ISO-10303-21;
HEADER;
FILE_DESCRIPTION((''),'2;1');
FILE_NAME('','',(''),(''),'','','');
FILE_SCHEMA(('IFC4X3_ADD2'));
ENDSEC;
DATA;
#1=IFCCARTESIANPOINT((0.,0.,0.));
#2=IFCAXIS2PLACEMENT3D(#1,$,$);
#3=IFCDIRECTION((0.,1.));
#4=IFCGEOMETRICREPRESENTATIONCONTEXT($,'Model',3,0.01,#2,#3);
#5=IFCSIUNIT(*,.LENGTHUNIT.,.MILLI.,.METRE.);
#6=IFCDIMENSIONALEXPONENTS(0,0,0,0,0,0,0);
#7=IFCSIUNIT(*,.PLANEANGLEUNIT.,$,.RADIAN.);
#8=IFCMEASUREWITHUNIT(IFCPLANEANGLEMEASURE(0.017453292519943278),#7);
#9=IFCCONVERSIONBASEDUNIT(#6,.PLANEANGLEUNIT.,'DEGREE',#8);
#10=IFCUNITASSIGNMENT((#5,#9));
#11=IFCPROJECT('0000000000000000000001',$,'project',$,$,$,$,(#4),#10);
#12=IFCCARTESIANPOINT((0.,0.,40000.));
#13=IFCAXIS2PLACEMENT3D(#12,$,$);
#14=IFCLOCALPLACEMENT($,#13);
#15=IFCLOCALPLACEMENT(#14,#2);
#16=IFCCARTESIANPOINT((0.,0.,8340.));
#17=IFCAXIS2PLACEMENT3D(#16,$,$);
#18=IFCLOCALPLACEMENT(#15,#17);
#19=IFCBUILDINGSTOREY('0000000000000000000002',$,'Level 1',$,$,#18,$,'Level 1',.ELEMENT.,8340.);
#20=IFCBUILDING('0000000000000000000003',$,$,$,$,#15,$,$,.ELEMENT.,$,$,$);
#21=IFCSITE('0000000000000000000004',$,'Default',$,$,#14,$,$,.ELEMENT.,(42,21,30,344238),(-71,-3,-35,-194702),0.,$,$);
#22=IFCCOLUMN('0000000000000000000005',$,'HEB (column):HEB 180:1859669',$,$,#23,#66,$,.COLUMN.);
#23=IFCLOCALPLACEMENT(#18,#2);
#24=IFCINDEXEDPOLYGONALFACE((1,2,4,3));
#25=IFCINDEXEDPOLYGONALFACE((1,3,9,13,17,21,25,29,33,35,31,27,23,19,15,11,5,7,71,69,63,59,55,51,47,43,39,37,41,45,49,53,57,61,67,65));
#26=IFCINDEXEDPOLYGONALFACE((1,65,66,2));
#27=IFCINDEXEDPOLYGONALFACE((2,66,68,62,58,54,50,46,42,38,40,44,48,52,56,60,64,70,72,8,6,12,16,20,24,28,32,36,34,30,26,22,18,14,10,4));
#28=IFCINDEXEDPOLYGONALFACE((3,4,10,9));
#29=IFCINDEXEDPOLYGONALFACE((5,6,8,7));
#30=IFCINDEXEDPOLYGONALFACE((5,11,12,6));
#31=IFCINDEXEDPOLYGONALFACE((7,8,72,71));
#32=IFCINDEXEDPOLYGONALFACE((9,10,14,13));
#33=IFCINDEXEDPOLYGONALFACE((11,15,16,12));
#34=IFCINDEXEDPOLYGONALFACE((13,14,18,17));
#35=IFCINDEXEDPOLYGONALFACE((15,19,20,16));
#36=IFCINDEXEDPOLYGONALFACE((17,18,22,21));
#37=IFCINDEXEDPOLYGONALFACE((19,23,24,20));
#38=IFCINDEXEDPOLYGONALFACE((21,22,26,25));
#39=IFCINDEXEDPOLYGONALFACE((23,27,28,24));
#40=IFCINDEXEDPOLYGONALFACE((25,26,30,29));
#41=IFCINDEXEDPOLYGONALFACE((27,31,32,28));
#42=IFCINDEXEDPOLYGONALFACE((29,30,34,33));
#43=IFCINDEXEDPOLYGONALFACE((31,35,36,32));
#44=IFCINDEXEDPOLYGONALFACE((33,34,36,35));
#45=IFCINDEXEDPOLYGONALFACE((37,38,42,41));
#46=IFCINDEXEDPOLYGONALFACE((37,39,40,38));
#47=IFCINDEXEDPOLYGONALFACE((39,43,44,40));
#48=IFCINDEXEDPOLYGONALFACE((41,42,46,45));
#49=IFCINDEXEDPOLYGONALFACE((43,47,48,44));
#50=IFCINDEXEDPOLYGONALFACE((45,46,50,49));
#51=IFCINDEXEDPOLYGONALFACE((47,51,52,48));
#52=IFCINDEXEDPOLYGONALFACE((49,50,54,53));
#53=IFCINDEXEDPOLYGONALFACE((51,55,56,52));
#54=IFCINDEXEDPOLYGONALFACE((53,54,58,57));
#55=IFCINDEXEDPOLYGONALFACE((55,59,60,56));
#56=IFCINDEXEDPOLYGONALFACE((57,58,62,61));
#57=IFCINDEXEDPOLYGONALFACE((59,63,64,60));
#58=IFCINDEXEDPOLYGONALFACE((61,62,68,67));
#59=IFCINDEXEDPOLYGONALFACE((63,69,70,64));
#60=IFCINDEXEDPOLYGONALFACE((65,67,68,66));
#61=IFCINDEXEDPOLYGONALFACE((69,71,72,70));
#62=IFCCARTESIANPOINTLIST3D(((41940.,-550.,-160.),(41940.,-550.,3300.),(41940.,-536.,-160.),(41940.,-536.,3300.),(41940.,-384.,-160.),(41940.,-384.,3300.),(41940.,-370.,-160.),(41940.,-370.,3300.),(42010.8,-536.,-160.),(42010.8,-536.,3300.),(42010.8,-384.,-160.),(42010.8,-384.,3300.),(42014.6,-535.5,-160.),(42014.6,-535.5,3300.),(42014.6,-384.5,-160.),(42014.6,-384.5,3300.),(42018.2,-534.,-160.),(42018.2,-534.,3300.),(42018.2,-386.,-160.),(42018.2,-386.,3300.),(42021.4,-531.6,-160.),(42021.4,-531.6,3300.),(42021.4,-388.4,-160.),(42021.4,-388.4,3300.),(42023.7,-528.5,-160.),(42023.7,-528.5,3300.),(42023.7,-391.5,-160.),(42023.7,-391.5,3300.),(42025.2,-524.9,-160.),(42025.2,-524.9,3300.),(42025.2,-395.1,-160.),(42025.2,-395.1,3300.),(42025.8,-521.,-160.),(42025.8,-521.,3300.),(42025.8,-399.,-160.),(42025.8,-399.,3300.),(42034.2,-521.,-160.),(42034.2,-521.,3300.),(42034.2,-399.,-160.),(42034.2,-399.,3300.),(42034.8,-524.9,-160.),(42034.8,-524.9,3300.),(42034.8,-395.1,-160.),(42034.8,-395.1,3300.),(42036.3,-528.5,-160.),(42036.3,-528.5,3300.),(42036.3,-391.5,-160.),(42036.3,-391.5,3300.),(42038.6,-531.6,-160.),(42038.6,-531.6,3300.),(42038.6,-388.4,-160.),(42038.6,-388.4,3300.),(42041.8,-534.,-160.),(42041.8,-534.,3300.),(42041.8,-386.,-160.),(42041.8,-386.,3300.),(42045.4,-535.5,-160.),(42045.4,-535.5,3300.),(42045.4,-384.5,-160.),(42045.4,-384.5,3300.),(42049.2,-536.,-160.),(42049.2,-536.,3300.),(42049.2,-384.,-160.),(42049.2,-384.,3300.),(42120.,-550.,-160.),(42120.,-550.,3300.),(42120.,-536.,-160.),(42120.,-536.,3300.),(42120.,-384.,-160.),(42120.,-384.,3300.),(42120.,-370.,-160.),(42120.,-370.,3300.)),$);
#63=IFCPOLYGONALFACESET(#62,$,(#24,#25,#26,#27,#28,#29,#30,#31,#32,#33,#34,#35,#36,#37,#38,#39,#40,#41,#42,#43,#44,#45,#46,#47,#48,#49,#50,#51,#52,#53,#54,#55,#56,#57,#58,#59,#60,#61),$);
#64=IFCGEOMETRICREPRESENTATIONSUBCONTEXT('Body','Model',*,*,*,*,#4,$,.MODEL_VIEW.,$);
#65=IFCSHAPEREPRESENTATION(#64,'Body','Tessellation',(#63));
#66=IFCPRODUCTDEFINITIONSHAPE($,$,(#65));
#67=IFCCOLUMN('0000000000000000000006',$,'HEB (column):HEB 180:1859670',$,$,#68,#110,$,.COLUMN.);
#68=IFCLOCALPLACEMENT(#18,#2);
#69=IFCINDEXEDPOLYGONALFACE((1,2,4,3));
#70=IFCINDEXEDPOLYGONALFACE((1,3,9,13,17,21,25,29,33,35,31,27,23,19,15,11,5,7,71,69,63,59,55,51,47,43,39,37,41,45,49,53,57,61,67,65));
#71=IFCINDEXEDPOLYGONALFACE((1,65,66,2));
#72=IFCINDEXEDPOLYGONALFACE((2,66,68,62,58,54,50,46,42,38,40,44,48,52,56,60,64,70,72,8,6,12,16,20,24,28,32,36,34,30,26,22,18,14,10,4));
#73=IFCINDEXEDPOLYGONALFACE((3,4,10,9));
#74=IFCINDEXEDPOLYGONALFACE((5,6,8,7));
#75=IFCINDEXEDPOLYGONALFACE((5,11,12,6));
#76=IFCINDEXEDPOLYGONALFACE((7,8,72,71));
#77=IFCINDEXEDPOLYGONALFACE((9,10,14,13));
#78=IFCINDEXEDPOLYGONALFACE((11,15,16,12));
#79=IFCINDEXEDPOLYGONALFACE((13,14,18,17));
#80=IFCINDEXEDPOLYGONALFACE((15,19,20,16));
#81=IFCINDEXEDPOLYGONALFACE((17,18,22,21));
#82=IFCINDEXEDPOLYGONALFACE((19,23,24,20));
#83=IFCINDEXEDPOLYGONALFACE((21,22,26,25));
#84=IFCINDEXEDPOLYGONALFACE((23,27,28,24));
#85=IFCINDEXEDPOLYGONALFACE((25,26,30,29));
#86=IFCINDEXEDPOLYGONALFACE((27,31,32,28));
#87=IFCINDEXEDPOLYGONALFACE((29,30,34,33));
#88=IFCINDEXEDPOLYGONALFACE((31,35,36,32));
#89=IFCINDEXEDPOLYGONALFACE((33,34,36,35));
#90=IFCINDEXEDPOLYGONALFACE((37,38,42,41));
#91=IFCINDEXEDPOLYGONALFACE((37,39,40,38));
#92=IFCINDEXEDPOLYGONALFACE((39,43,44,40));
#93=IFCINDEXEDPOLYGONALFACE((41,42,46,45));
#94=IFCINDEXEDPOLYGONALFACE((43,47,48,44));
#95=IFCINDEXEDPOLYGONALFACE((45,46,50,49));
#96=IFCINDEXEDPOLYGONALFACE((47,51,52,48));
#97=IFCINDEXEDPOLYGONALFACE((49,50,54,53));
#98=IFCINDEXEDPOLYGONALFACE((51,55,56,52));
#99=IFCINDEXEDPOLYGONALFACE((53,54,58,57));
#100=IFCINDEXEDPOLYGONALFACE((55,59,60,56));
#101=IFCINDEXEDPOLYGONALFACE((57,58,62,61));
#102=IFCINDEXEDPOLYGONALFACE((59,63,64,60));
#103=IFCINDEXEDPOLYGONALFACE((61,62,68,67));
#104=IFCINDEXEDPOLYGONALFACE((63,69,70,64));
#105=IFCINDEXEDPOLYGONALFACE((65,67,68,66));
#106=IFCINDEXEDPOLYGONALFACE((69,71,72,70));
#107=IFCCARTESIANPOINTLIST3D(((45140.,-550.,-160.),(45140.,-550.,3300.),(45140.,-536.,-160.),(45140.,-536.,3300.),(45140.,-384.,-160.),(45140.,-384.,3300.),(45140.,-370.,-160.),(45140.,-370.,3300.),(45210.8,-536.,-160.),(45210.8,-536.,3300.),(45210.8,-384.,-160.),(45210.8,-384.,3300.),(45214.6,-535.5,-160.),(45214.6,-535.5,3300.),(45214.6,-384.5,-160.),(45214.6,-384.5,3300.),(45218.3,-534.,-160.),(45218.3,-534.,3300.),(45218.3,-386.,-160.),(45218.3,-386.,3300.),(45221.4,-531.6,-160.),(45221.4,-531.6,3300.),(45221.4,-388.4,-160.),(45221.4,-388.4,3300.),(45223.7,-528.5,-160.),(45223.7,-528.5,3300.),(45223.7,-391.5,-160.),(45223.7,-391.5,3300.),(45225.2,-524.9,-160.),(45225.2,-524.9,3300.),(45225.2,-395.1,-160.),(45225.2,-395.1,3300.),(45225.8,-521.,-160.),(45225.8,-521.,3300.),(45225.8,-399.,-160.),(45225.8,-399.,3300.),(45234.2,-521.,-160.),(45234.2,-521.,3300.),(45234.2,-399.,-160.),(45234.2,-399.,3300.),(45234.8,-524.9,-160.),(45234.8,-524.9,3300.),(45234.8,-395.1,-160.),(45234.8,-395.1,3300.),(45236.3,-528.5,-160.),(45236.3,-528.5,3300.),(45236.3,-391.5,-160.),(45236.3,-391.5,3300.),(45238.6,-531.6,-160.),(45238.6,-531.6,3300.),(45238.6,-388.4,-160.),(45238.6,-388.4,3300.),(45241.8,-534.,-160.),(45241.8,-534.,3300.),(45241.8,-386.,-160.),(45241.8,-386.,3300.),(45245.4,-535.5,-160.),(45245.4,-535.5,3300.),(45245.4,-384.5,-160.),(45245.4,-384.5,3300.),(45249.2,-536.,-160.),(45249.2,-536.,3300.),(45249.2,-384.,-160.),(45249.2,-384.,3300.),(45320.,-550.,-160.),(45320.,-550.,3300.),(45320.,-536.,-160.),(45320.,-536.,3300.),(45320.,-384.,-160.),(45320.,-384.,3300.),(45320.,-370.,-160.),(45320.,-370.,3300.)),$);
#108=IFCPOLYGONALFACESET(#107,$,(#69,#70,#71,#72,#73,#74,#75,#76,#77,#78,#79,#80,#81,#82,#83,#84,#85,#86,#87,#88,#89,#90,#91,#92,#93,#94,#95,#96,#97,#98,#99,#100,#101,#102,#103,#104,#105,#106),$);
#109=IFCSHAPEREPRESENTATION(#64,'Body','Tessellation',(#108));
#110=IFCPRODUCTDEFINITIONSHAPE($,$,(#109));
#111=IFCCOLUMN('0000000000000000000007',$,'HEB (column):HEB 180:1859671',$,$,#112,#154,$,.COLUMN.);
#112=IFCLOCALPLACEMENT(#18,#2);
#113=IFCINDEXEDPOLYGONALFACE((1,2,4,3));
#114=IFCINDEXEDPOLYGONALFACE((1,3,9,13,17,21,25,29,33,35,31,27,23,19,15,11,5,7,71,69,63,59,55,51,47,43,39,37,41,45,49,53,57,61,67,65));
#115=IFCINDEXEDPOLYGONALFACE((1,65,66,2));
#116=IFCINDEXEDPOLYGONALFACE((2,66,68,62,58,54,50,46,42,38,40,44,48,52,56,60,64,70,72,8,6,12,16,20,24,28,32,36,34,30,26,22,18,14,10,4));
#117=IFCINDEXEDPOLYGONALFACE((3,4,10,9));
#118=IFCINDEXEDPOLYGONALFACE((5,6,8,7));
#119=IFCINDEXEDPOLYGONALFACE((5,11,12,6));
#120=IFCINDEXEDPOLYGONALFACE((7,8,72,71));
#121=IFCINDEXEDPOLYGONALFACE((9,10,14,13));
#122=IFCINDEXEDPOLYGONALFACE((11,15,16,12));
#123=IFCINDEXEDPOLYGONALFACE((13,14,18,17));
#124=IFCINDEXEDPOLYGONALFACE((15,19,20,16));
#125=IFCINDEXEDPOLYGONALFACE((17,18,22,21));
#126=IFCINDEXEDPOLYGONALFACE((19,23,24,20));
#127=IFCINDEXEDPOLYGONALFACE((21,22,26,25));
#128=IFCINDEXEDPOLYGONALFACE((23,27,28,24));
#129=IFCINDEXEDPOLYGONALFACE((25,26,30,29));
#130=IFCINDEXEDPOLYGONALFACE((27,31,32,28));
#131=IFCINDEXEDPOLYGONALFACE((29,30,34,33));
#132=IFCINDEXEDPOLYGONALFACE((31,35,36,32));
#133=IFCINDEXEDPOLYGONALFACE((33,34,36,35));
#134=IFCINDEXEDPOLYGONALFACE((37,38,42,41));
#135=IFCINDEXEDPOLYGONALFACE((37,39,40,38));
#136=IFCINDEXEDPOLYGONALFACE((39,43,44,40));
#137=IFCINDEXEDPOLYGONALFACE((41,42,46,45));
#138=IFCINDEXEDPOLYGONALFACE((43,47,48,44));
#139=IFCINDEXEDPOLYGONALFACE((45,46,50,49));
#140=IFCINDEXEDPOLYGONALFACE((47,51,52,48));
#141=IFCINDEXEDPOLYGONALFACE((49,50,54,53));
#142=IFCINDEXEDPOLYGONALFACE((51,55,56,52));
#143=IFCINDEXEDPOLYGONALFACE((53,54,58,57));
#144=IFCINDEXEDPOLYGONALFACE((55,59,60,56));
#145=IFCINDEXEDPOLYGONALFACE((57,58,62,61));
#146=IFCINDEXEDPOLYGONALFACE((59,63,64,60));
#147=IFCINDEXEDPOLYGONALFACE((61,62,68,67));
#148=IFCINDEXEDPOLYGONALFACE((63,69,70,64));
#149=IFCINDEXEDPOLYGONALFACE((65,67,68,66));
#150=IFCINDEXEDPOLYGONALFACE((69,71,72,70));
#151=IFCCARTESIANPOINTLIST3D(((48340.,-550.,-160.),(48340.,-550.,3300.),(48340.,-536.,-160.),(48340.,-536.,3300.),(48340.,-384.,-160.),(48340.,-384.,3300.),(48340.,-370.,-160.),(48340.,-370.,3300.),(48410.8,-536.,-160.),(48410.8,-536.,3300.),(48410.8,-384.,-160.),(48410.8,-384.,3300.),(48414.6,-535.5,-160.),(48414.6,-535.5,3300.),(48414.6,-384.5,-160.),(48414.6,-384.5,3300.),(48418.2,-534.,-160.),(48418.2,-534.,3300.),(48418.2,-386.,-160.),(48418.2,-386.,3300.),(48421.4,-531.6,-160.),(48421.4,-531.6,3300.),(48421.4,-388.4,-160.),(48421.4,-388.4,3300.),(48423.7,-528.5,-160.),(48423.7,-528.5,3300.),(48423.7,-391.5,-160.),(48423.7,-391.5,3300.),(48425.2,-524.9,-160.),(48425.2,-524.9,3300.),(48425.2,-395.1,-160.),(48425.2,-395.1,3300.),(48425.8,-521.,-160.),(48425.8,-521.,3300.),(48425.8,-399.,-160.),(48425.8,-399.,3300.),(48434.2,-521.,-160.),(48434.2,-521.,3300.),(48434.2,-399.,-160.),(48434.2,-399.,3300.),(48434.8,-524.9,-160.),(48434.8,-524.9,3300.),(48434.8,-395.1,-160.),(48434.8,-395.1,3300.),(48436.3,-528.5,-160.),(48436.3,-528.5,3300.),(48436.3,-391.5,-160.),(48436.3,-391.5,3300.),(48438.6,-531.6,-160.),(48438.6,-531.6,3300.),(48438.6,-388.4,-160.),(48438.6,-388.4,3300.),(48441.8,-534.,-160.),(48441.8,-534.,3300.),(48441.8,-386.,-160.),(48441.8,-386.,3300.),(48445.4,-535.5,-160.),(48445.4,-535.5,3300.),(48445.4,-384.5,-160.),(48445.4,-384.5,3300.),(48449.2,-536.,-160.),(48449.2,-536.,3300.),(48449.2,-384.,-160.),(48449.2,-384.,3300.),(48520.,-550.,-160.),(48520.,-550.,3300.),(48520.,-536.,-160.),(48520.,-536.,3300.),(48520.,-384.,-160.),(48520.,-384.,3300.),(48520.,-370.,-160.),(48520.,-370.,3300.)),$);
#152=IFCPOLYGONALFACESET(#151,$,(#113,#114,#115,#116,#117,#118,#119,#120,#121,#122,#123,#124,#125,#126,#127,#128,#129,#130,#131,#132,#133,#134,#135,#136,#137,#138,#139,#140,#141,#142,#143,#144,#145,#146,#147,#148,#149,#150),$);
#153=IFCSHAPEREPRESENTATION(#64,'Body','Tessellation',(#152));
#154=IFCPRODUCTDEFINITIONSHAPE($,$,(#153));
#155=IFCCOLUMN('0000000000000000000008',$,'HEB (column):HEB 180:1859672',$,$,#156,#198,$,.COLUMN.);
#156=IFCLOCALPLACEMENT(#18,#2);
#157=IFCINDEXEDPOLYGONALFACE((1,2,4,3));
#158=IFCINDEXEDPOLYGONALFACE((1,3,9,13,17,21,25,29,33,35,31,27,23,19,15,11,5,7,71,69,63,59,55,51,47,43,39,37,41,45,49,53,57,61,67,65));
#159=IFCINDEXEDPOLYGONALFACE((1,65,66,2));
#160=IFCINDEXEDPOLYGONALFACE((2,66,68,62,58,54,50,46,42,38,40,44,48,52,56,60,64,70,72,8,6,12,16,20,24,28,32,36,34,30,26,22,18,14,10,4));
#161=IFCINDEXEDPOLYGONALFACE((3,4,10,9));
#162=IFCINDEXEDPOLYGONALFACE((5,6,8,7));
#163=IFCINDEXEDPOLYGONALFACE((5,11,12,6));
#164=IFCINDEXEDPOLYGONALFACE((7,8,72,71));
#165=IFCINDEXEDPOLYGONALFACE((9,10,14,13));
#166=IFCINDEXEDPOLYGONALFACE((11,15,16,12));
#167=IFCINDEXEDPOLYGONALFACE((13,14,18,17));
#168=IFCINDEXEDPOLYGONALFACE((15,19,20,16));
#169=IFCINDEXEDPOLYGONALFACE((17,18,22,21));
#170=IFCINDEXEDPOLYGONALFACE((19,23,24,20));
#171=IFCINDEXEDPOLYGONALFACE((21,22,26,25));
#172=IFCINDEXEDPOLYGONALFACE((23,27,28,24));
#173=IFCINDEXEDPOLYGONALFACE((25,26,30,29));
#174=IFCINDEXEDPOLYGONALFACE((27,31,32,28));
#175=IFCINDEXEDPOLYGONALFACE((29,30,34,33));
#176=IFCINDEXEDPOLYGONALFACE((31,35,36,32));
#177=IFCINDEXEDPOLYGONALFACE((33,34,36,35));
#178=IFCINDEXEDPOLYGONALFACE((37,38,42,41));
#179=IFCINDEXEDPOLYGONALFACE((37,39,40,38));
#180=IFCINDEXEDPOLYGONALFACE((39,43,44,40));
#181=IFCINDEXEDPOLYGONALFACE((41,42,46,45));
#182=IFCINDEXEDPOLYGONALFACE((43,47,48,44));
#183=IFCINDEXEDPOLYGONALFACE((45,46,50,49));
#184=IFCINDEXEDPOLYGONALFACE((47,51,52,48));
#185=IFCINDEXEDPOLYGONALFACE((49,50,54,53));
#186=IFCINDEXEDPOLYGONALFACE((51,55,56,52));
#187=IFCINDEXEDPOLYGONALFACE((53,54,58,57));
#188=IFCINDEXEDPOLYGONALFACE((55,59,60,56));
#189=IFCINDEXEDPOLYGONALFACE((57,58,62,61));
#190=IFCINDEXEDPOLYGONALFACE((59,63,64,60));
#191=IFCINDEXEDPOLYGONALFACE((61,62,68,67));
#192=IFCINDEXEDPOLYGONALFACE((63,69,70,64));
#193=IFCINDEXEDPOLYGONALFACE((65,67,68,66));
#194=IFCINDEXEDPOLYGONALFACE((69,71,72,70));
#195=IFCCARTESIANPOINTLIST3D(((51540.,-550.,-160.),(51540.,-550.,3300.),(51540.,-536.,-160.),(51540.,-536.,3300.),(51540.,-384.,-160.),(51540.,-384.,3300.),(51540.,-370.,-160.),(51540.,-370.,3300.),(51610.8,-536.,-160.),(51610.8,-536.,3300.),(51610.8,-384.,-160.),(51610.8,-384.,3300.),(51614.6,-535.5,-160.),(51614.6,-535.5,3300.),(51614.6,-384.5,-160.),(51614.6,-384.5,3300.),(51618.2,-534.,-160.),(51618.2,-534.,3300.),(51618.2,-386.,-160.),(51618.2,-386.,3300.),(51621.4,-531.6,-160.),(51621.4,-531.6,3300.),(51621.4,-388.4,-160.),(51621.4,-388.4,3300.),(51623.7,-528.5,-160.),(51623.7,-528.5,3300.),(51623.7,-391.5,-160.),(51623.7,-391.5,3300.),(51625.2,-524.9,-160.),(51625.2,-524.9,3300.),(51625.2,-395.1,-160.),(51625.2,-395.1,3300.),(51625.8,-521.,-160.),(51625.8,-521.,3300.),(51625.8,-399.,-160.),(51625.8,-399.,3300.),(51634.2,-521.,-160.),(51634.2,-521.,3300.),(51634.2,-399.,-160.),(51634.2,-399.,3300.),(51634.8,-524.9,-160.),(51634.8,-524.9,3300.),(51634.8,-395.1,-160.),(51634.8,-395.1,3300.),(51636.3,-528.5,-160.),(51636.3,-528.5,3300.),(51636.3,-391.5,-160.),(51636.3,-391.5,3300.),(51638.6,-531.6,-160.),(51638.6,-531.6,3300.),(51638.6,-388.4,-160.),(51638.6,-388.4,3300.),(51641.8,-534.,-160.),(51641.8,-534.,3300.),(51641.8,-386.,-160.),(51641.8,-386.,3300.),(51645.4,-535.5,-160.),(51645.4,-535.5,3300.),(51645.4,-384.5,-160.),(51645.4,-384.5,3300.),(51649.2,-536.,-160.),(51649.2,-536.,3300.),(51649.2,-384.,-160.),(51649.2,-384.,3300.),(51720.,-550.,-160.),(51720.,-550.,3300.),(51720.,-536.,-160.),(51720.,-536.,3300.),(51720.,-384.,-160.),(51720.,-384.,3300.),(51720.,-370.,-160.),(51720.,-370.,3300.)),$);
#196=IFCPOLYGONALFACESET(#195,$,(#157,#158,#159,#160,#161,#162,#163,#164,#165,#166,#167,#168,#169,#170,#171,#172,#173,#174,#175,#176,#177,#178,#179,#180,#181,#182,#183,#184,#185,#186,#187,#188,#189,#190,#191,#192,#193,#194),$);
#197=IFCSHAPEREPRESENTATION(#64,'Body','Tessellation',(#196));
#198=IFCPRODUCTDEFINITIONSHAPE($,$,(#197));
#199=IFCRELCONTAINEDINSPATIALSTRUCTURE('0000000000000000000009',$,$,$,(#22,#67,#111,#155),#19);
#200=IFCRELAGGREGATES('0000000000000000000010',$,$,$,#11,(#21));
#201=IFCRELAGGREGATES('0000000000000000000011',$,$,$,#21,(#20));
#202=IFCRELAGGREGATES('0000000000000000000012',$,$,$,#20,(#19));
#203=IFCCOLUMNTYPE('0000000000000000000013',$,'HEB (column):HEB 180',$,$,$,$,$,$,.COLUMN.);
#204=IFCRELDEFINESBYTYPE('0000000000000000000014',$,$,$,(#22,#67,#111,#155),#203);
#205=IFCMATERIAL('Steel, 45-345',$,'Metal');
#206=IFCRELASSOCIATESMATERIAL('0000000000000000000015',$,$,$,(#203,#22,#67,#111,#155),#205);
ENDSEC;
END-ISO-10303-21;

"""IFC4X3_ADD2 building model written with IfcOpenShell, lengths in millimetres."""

from ifc_helpers import new_model, entity, si_unit, converted_unit, direction, frame, origin, origin_2d_with_axis, place, context, subcontext, project, spatial, i_section, extrude, source, transform, mapped, material, material_profile, profile_set, profile_usage, type_object, type_shapes, element, save


model = new_model("IFC4X3_ADD2")

# Units and contexts
model_context = context("Model", 3, precision=0.01, world=origin(), true_north=direction((0.0, 1.0)))
body_context = subcontext(model_context, "Body", "Model", "MODEL_VIEW")
ifc_project = project(units=[si_unit("LENGTHUNIT", "METRE", prefix="MILLI"), converted_unit("PLANEANGLEUNIT", "DEGREE", entity("IfcPlaneAngleMeasure", 0.017453292519943278), si_unit("PLANEANGLEUNIT", "RADIAN"), dimensions=[0, 0, 0, 0, 0, 0, 0])], contexts=[model_context])

# Site, building, storey
site_placement = place(None, frame((0.0, 0.0, 40000.0)))
site = spatial("IfcSite", under=ifc_project, at=site_placement, Name="Default", CompositionType="ELEMENT", RefLatitude=(42, 21, 30, 344238), RefLongitude=(-71, -3, -35, -194702), RefElevation=0.0)
building_placement = place(site_placement, origin())
building = spatial("IfcBuilding", under=site, at=building_placement, CompositionType="ELEMENT")
storey_placement = place(building_placement, frame((0.0, 0.0, 8340.0)))
storey = spatial("IfcBuildingStorey", under=building, at=storey_placement, Name="Level 1", LongName="Level 1", CompositionType="ELEMENT", Elevation=8340.0)

# Columns
ifc_material = material(Name="Steel, 45-345", Category="Metal")
ifc_material_profile_1 = material_profile(ifc_material, i_section(OverallWidth=180.0, OverallDepth=180.0, WebThickness=8.5, FlangeThickness=14.0, FilletRadius=15.0, at=origin_2d_with_axis()), Name="HEB 180")
ifc_profile_set_1 = profile_set([ifc_material_profile_1], Name="HEB 180")
ifc_profile_usage_1 = profile_usage(ifc_profile_set_1)
column_type_1 = type_object("IfcColumnType", Name="HEB (column):HEB 180", PredefinedType="COLUMN", material=ifc_profile_set_1)
shared_shape_1 = source(origin(), body_context, "Body", "SweptSolid", [
    extrude(i_section(OverallWidth=180.0, OverallDepth=180.0, WebThickness=8.5, FlangeThickness=14.0, FilletRadius=15.0, at=origin_2d_with_axis()), frame((0.0, 0.0, 8180.0), z_axis=(0.0, 0.0, 1.0), x_axis=(-1.0, 0.0, 0.0)), (0.0, 0.0, 1.0), 3460.0),
])
type_shapes(column_type_1, [shared_shape_1])
for number, where, name in (
    (1, (42030.0, -460.0, -8340.0), "HEB (column):HEB 180:1859669"),
    (2, (45230.0, -460.0, -8340.0), "HEB (column):HEB 180:1859670"),
    (3, (48430.0, -460.0, -8340.0), "HEB (column):HEB 180:1859671"),
    (4, (51630.0, -460.0, -8340.0), "HEB (column):HEB 180:1859672"),
):
    element("IfcColumn", number, at=place(storey_placement, frame(where)), inside=storey, type_object=column_type_1, material=ifc_profile_usage_1, Name=name, PredefinedType="COLUMN", context=body_context, shape_type="MappedRepresentation", body=[
        mapped(shared_shape_1, transform((0.0, 0.0, 0.0), scale=1.0)),
    ])

save(model, "model.ifc")
